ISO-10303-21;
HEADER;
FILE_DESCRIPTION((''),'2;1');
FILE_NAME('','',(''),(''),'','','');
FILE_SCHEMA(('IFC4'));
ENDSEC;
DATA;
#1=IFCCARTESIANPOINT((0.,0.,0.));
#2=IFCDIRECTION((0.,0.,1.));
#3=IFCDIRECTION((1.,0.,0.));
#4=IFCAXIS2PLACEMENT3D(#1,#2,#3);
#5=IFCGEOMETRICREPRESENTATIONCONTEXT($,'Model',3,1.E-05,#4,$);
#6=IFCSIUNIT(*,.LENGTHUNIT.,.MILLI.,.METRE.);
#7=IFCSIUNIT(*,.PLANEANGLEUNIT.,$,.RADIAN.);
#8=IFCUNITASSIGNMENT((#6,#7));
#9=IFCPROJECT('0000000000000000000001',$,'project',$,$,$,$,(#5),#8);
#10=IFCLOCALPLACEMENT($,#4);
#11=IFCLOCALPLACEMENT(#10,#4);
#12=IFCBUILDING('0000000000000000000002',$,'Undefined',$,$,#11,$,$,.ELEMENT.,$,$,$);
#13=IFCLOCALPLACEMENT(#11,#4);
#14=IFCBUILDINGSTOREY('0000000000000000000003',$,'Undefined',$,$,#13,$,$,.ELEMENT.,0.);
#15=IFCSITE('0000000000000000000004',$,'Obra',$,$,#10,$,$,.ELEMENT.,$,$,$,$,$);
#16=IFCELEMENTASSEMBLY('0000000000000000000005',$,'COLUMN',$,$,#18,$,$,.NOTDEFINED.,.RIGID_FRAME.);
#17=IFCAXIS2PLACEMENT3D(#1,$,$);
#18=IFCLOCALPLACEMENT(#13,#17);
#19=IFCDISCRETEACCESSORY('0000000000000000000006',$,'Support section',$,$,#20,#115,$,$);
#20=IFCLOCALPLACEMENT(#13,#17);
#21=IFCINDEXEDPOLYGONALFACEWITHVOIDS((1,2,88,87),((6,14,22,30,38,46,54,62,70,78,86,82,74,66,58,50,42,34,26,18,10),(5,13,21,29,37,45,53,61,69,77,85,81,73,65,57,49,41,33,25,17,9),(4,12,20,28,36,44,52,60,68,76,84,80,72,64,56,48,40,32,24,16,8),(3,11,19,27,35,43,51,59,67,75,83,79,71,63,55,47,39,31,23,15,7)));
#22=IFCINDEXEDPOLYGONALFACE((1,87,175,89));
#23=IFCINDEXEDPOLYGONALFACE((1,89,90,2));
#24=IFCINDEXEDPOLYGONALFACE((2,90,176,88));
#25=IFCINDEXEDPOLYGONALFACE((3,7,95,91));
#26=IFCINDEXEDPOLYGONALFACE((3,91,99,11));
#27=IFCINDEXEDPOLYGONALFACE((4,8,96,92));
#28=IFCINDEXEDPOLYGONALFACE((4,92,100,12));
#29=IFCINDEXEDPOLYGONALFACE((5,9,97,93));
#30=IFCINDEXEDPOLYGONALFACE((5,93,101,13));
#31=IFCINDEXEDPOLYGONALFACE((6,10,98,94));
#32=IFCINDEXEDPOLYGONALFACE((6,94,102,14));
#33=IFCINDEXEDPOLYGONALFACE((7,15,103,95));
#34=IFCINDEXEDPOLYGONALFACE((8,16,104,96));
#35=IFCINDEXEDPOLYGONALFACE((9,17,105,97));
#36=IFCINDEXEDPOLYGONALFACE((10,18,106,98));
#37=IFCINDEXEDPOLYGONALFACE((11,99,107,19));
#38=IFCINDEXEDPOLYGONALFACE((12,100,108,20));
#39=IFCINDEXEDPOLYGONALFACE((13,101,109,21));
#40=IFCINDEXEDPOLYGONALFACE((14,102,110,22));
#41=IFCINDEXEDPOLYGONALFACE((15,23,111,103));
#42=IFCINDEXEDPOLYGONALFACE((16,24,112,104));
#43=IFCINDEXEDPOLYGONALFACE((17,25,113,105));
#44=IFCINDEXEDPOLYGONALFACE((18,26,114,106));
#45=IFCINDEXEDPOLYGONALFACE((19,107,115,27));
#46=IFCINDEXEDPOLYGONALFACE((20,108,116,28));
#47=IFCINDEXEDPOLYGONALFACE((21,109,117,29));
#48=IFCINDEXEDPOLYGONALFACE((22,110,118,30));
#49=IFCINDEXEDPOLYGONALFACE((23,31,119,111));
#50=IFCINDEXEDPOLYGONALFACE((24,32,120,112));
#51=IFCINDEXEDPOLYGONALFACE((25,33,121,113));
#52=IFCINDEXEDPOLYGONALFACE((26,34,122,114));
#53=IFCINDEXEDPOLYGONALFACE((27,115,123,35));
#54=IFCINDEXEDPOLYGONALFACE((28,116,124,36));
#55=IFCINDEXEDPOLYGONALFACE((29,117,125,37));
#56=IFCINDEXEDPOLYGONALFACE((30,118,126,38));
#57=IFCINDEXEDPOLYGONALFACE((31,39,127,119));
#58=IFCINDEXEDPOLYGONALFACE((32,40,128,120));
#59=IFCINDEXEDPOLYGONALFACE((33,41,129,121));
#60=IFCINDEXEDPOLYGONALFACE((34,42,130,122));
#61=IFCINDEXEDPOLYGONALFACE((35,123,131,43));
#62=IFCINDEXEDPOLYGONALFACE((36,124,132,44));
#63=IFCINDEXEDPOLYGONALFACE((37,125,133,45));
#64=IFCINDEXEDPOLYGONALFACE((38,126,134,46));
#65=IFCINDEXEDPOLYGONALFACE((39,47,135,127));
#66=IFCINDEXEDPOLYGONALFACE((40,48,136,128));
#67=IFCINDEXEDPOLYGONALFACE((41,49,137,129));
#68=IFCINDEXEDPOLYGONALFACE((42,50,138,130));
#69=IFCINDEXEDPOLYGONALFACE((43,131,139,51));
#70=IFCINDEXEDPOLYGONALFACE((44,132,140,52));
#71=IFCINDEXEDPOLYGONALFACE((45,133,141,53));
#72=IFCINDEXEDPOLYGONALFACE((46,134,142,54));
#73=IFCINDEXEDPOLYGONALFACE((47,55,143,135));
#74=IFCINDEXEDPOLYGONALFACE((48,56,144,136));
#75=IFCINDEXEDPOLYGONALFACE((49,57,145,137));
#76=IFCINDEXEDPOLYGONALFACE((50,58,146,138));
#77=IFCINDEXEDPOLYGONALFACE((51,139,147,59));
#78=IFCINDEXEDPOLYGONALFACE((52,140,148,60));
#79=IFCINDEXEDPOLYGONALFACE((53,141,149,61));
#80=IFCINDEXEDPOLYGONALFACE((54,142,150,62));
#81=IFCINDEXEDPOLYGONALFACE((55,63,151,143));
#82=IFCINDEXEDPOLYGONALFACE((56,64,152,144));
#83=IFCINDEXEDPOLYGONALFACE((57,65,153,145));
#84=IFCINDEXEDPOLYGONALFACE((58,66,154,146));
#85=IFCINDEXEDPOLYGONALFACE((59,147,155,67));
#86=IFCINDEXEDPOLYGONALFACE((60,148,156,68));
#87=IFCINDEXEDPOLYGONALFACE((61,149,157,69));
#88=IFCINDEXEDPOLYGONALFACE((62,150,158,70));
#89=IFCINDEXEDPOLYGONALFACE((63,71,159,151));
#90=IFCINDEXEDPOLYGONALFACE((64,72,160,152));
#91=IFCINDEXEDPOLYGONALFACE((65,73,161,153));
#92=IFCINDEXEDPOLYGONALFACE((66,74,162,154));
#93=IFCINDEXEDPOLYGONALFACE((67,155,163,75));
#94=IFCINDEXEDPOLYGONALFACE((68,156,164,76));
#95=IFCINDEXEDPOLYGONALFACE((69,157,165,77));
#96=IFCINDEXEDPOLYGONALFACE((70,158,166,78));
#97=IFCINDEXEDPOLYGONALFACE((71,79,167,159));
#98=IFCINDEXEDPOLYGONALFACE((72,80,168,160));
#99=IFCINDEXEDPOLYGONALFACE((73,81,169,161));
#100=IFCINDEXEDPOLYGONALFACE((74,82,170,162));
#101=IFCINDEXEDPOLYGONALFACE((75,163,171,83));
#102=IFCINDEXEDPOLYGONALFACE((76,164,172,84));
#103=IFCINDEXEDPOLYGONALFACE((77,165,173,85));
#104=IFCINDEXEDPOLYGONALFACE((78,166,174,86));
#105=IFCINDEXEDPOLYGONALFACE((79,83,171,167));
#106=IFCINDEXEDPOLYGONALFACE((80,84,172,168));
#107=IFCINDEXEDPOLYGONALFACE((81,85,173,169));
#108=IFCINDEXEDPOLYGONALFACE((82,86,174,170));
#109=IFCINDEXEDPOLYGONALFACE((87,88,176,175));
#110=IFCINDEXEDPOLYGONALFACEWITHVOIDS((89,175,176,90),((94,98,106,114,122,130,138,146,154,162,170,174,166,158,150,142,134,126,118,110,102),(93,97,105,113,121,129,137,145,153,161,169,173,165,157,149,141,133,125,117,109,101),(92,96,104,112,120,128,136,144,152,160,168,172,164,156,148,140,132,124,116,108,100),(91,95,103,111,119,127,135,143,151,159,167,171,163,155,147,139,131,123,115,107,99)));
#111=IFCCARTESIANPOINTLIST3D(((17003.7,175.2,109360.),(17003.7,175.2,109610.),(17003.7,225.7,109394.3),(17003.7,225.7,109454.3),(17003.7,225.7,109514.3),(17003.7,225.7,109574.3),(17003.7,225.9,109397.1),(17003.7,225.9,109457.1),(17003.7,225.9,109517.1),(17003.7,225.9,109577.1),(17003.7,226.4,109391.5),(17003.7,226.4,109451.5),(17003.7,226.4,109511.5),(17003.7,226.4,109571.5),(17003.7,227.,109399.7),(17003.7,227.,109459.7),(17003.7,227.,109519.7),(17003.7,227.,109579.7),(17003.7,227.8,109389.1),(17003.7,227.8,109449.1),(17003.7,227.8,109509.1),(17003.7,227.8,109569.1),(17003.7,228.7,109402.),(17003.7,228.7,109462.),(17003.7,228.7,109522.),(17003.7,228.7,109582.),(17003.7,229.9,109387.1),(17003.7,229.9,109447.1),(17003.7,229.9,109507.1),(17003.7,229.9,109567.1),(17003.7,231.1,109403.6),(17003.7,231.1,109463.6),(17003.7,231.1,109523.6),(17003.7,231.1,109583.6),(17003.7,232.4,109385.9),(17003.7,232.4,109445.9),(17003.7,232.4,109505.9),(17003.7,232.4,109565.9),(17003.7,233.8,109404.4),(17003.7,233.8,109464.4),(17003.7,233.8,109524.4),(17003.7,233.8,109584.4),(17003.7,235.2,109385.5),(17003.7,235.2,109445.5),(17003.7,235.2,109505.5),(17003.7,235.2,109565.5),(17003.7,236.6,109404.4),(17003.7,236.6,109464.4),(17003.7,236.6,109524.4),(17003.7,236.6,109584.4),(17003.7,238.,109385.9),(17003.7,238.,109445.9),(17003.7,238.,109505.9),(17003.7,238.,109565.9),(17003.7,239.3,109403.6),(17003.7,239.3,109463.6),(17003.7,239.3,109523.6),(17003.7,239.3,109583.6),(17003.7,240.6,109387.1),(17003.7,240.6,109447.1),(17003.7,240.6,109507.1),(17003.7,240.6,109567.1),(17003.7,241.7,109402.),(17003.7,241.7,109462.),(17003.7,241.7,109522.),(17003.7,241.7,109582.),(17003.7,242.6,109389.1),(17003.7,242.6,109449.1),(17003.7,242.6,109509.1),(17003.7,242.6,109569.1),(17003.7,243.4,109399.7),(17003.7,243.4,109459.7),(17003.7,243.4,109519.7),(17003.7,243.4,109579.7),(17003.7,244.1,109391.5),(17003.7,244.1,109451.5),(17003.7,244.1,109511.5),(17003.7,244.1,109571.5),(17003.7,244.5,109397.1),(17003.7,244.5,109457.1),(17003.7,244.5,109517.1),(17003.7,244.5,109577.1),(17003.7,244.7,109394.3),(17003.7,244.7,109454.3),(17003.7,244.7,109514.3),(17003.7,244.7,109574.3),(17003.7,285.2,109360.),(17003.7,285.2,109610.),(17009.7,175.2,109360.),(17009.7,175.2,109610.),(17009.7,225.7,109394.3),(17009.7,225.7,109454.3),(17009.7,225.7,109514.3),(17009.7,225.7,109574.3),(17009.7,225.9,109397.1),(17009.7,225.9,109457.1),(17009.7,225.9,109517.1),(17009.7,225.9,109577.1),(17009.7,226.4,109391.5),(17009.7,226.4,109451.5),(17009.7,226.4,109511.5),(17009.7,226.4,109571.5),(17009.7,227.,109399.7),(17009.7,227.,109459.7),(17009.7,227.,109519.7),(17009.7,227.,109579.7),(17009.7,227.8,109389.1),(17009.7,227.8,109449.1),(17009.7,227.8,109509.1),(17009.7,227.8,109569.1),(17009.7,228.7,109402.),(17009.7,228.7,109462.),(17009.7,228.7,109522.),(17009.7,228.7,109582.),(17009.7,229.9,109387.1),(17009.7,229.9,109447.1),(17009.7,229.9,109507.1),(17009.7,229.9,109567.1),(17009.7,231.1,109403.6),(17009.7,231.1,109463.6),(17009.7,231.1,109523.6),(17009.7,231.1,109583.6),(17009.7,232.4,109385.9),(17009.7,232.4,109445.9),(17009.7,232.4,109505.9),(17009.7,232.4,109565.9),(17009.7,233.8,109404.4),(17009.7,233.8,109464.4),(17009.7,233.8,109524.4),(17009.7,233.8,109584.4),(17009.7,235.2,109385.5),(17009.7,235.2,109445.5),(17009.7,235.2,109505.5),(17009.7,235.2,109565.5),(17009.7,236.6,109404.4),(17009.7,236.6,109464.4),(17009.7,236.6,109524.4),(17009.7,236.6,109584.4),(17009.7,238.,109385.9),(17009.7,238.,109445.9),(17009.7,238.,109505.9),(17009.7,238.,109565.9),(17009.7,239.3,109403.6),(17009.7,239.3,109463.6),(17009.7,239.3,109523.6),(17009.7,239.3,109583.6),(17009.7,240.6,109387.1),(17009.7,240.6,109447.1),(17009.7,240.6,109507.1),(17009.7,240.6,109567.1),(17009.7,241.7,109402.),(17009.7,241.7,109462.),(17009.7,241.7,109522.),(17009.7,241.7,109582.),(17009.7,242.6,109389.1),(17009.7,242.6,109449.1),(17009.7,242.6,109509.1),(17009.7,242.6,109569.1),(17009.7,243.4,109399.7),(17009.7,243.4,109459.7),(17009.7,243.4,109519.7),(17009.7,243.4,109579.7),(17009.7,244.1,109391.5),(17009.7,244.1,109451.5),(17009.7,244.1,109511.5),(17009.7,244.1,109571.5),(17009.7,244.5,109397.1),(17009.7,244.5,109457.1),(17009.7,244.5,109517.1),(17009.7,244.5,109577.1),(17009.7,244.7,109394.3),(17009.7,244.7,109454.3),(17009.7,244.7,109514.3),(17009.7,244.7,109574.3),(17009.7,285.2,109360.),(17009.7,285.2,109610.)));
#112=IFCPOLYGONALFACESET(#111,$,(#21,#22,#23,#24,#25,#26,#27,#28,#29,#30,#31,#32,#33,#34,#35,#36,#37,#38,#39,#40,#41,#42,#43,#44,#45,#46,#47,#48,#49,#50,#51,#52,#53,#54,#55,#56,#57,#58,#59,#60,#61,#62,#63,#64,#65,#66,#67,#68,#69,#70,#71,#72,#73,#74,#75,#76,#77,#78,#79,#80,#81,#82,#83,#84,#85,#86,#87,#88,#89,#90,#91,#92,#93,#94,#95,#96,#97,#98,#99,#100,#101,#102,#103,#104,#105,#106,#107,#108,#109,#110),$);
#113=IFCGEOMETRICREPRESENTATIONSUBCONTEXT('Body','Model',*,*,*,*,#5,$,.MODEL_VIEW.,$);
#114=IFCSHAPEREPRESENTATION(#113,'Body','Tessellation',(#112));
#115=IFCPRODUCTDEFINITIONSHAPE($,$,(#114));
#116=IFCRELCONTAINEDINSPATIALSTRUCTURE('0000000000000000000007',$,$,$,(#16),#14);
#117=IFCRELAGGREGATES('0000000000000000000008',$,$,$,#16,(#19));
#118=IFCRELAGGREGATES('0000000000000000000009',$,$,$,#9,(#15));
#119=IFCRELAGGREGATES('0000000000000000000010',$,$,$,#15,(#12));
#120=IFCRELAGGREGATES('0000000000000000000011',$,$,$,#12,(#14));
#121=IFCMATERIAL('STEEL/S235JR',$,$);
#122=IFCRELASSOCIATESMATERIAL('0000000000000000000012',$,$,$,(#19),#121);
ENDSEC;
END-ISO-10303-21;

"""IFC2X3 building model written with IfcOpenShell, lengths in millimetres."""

from ifc_helpers import new_model, si_unit, frame, origin_with_axes, origin_2d_with_axis, place, context, subcontext, project, spatial, rectangle, circle, extrude, source, transform, mapped, material, element, aggregate, save


model = new_model("IFC2X3")

# Units and contexts
model_context = context("Model", 3, precision=1e-05, world=origin_with_axes())
body_context = subcontext(model_context, "Body", "Model", "MODEL_VIEW")
ifc_project = project(units=[si_unit("LENGTHUNIT", "METRE", prefix="MILLI"), si_unit("PLANEANGLEUNIT", "RADIAN")], contexts=[model_context])

# Site, building, storey
site_placement = place(None, origin_with_axes())
site = spatial("IfcSite", under=ifc_project, at=site_placement, Name="Obra", CompositionType="ELEMENT")
building_placement = place(site_placement, origin_with_axes())
building = spatial("IfcBuilding", under=site, at=building_placement, Name="Undefined", CompositionType="ELEMENT")
storey_placement = place(building_placement, origin_with_axes())
storey = spatial("IfcBuildingStorey", under=building, at=storey_placement, Name="Undefined", CompositionType="ELEMENT", Elevation=0.0)

# Element assembly, discrete accessory, opening
assembly_1_placement = place(storey_placement, origin_with_axes())
assembly_1 = element("IfcElementAssembly", 1, at=assembly_1_placement, inside=storey, Name="COLUMN", AssemblyPlace="NOTDEFINED", PredefinedType="RIGID_FRAME")
ifc_material_1 = material(Name="STEEL/S235JR")
discrete_accessory_1_placement = place(assembly_1_placement, frame((17006.7, 230.2, 109360.0), z_axis=(0.0, 0.0, 1.0), x_axis=(0.0, -1.0, 0.0)))
discrete_accessory_1 = element("IfcDiscreteAccessory", 2, at=discrete_accessory_1_placement, material=ifc_material_1, Name="Support section", context=body_context, shape_type="SweptSolid", body=[
    extrude(rectangle(XDim=6.0, YDim=110.0, at=origin_2d_with_axis()), frame((0.0, 0.0, 250.0), z_axis=(0.0, 0.0, -1.0), x_axis=(0.0, 1.0, 0.0)), (0.0, 0.0, 1.0), 250.0),
])
shared_shape_1 = source(origin_with_axes(), body_context, "Body", "SweptSolid", [
    extrude(circle(Radius=9.5, at=origin_2d_with_axis()), frame((0.0, -9.8, 0.0), z_axis=(0.0, 1.0, 0.0), x_axis=(1.0, 0.0, 0.0)), (0.0, 0.0, 1.0), 6.2),
])
opening_1_placement = place(assembly_1_placement, frame((17000.0, 185.2, 109650.0), z_axis=(0.0, 1.0, 0.0), x_axis=(0.0, 0.0, -1.0)))
element("IfcOpeningElement", 3, at=opening_1_placement, cuts=discrete_accessory_1, ObjectType="Opening", context=body_context, shape_type="MappedRepresentation", body=[
    mapped(shared_shape_1, transform((75.0, 0.0, 50.0))),
    mapped(shared_shape_1, transform((135.0, 0.0, 50.0))),
    mapped(shared_shape_1, transform((195.0, 0.0, 50.0))),
    mapped(shared_shape_1, transform((255.0, 0.0, 50.0))),
])
aggregate(assembly_1, [discrete_accessory_1])

save(model, "model.ifc")
